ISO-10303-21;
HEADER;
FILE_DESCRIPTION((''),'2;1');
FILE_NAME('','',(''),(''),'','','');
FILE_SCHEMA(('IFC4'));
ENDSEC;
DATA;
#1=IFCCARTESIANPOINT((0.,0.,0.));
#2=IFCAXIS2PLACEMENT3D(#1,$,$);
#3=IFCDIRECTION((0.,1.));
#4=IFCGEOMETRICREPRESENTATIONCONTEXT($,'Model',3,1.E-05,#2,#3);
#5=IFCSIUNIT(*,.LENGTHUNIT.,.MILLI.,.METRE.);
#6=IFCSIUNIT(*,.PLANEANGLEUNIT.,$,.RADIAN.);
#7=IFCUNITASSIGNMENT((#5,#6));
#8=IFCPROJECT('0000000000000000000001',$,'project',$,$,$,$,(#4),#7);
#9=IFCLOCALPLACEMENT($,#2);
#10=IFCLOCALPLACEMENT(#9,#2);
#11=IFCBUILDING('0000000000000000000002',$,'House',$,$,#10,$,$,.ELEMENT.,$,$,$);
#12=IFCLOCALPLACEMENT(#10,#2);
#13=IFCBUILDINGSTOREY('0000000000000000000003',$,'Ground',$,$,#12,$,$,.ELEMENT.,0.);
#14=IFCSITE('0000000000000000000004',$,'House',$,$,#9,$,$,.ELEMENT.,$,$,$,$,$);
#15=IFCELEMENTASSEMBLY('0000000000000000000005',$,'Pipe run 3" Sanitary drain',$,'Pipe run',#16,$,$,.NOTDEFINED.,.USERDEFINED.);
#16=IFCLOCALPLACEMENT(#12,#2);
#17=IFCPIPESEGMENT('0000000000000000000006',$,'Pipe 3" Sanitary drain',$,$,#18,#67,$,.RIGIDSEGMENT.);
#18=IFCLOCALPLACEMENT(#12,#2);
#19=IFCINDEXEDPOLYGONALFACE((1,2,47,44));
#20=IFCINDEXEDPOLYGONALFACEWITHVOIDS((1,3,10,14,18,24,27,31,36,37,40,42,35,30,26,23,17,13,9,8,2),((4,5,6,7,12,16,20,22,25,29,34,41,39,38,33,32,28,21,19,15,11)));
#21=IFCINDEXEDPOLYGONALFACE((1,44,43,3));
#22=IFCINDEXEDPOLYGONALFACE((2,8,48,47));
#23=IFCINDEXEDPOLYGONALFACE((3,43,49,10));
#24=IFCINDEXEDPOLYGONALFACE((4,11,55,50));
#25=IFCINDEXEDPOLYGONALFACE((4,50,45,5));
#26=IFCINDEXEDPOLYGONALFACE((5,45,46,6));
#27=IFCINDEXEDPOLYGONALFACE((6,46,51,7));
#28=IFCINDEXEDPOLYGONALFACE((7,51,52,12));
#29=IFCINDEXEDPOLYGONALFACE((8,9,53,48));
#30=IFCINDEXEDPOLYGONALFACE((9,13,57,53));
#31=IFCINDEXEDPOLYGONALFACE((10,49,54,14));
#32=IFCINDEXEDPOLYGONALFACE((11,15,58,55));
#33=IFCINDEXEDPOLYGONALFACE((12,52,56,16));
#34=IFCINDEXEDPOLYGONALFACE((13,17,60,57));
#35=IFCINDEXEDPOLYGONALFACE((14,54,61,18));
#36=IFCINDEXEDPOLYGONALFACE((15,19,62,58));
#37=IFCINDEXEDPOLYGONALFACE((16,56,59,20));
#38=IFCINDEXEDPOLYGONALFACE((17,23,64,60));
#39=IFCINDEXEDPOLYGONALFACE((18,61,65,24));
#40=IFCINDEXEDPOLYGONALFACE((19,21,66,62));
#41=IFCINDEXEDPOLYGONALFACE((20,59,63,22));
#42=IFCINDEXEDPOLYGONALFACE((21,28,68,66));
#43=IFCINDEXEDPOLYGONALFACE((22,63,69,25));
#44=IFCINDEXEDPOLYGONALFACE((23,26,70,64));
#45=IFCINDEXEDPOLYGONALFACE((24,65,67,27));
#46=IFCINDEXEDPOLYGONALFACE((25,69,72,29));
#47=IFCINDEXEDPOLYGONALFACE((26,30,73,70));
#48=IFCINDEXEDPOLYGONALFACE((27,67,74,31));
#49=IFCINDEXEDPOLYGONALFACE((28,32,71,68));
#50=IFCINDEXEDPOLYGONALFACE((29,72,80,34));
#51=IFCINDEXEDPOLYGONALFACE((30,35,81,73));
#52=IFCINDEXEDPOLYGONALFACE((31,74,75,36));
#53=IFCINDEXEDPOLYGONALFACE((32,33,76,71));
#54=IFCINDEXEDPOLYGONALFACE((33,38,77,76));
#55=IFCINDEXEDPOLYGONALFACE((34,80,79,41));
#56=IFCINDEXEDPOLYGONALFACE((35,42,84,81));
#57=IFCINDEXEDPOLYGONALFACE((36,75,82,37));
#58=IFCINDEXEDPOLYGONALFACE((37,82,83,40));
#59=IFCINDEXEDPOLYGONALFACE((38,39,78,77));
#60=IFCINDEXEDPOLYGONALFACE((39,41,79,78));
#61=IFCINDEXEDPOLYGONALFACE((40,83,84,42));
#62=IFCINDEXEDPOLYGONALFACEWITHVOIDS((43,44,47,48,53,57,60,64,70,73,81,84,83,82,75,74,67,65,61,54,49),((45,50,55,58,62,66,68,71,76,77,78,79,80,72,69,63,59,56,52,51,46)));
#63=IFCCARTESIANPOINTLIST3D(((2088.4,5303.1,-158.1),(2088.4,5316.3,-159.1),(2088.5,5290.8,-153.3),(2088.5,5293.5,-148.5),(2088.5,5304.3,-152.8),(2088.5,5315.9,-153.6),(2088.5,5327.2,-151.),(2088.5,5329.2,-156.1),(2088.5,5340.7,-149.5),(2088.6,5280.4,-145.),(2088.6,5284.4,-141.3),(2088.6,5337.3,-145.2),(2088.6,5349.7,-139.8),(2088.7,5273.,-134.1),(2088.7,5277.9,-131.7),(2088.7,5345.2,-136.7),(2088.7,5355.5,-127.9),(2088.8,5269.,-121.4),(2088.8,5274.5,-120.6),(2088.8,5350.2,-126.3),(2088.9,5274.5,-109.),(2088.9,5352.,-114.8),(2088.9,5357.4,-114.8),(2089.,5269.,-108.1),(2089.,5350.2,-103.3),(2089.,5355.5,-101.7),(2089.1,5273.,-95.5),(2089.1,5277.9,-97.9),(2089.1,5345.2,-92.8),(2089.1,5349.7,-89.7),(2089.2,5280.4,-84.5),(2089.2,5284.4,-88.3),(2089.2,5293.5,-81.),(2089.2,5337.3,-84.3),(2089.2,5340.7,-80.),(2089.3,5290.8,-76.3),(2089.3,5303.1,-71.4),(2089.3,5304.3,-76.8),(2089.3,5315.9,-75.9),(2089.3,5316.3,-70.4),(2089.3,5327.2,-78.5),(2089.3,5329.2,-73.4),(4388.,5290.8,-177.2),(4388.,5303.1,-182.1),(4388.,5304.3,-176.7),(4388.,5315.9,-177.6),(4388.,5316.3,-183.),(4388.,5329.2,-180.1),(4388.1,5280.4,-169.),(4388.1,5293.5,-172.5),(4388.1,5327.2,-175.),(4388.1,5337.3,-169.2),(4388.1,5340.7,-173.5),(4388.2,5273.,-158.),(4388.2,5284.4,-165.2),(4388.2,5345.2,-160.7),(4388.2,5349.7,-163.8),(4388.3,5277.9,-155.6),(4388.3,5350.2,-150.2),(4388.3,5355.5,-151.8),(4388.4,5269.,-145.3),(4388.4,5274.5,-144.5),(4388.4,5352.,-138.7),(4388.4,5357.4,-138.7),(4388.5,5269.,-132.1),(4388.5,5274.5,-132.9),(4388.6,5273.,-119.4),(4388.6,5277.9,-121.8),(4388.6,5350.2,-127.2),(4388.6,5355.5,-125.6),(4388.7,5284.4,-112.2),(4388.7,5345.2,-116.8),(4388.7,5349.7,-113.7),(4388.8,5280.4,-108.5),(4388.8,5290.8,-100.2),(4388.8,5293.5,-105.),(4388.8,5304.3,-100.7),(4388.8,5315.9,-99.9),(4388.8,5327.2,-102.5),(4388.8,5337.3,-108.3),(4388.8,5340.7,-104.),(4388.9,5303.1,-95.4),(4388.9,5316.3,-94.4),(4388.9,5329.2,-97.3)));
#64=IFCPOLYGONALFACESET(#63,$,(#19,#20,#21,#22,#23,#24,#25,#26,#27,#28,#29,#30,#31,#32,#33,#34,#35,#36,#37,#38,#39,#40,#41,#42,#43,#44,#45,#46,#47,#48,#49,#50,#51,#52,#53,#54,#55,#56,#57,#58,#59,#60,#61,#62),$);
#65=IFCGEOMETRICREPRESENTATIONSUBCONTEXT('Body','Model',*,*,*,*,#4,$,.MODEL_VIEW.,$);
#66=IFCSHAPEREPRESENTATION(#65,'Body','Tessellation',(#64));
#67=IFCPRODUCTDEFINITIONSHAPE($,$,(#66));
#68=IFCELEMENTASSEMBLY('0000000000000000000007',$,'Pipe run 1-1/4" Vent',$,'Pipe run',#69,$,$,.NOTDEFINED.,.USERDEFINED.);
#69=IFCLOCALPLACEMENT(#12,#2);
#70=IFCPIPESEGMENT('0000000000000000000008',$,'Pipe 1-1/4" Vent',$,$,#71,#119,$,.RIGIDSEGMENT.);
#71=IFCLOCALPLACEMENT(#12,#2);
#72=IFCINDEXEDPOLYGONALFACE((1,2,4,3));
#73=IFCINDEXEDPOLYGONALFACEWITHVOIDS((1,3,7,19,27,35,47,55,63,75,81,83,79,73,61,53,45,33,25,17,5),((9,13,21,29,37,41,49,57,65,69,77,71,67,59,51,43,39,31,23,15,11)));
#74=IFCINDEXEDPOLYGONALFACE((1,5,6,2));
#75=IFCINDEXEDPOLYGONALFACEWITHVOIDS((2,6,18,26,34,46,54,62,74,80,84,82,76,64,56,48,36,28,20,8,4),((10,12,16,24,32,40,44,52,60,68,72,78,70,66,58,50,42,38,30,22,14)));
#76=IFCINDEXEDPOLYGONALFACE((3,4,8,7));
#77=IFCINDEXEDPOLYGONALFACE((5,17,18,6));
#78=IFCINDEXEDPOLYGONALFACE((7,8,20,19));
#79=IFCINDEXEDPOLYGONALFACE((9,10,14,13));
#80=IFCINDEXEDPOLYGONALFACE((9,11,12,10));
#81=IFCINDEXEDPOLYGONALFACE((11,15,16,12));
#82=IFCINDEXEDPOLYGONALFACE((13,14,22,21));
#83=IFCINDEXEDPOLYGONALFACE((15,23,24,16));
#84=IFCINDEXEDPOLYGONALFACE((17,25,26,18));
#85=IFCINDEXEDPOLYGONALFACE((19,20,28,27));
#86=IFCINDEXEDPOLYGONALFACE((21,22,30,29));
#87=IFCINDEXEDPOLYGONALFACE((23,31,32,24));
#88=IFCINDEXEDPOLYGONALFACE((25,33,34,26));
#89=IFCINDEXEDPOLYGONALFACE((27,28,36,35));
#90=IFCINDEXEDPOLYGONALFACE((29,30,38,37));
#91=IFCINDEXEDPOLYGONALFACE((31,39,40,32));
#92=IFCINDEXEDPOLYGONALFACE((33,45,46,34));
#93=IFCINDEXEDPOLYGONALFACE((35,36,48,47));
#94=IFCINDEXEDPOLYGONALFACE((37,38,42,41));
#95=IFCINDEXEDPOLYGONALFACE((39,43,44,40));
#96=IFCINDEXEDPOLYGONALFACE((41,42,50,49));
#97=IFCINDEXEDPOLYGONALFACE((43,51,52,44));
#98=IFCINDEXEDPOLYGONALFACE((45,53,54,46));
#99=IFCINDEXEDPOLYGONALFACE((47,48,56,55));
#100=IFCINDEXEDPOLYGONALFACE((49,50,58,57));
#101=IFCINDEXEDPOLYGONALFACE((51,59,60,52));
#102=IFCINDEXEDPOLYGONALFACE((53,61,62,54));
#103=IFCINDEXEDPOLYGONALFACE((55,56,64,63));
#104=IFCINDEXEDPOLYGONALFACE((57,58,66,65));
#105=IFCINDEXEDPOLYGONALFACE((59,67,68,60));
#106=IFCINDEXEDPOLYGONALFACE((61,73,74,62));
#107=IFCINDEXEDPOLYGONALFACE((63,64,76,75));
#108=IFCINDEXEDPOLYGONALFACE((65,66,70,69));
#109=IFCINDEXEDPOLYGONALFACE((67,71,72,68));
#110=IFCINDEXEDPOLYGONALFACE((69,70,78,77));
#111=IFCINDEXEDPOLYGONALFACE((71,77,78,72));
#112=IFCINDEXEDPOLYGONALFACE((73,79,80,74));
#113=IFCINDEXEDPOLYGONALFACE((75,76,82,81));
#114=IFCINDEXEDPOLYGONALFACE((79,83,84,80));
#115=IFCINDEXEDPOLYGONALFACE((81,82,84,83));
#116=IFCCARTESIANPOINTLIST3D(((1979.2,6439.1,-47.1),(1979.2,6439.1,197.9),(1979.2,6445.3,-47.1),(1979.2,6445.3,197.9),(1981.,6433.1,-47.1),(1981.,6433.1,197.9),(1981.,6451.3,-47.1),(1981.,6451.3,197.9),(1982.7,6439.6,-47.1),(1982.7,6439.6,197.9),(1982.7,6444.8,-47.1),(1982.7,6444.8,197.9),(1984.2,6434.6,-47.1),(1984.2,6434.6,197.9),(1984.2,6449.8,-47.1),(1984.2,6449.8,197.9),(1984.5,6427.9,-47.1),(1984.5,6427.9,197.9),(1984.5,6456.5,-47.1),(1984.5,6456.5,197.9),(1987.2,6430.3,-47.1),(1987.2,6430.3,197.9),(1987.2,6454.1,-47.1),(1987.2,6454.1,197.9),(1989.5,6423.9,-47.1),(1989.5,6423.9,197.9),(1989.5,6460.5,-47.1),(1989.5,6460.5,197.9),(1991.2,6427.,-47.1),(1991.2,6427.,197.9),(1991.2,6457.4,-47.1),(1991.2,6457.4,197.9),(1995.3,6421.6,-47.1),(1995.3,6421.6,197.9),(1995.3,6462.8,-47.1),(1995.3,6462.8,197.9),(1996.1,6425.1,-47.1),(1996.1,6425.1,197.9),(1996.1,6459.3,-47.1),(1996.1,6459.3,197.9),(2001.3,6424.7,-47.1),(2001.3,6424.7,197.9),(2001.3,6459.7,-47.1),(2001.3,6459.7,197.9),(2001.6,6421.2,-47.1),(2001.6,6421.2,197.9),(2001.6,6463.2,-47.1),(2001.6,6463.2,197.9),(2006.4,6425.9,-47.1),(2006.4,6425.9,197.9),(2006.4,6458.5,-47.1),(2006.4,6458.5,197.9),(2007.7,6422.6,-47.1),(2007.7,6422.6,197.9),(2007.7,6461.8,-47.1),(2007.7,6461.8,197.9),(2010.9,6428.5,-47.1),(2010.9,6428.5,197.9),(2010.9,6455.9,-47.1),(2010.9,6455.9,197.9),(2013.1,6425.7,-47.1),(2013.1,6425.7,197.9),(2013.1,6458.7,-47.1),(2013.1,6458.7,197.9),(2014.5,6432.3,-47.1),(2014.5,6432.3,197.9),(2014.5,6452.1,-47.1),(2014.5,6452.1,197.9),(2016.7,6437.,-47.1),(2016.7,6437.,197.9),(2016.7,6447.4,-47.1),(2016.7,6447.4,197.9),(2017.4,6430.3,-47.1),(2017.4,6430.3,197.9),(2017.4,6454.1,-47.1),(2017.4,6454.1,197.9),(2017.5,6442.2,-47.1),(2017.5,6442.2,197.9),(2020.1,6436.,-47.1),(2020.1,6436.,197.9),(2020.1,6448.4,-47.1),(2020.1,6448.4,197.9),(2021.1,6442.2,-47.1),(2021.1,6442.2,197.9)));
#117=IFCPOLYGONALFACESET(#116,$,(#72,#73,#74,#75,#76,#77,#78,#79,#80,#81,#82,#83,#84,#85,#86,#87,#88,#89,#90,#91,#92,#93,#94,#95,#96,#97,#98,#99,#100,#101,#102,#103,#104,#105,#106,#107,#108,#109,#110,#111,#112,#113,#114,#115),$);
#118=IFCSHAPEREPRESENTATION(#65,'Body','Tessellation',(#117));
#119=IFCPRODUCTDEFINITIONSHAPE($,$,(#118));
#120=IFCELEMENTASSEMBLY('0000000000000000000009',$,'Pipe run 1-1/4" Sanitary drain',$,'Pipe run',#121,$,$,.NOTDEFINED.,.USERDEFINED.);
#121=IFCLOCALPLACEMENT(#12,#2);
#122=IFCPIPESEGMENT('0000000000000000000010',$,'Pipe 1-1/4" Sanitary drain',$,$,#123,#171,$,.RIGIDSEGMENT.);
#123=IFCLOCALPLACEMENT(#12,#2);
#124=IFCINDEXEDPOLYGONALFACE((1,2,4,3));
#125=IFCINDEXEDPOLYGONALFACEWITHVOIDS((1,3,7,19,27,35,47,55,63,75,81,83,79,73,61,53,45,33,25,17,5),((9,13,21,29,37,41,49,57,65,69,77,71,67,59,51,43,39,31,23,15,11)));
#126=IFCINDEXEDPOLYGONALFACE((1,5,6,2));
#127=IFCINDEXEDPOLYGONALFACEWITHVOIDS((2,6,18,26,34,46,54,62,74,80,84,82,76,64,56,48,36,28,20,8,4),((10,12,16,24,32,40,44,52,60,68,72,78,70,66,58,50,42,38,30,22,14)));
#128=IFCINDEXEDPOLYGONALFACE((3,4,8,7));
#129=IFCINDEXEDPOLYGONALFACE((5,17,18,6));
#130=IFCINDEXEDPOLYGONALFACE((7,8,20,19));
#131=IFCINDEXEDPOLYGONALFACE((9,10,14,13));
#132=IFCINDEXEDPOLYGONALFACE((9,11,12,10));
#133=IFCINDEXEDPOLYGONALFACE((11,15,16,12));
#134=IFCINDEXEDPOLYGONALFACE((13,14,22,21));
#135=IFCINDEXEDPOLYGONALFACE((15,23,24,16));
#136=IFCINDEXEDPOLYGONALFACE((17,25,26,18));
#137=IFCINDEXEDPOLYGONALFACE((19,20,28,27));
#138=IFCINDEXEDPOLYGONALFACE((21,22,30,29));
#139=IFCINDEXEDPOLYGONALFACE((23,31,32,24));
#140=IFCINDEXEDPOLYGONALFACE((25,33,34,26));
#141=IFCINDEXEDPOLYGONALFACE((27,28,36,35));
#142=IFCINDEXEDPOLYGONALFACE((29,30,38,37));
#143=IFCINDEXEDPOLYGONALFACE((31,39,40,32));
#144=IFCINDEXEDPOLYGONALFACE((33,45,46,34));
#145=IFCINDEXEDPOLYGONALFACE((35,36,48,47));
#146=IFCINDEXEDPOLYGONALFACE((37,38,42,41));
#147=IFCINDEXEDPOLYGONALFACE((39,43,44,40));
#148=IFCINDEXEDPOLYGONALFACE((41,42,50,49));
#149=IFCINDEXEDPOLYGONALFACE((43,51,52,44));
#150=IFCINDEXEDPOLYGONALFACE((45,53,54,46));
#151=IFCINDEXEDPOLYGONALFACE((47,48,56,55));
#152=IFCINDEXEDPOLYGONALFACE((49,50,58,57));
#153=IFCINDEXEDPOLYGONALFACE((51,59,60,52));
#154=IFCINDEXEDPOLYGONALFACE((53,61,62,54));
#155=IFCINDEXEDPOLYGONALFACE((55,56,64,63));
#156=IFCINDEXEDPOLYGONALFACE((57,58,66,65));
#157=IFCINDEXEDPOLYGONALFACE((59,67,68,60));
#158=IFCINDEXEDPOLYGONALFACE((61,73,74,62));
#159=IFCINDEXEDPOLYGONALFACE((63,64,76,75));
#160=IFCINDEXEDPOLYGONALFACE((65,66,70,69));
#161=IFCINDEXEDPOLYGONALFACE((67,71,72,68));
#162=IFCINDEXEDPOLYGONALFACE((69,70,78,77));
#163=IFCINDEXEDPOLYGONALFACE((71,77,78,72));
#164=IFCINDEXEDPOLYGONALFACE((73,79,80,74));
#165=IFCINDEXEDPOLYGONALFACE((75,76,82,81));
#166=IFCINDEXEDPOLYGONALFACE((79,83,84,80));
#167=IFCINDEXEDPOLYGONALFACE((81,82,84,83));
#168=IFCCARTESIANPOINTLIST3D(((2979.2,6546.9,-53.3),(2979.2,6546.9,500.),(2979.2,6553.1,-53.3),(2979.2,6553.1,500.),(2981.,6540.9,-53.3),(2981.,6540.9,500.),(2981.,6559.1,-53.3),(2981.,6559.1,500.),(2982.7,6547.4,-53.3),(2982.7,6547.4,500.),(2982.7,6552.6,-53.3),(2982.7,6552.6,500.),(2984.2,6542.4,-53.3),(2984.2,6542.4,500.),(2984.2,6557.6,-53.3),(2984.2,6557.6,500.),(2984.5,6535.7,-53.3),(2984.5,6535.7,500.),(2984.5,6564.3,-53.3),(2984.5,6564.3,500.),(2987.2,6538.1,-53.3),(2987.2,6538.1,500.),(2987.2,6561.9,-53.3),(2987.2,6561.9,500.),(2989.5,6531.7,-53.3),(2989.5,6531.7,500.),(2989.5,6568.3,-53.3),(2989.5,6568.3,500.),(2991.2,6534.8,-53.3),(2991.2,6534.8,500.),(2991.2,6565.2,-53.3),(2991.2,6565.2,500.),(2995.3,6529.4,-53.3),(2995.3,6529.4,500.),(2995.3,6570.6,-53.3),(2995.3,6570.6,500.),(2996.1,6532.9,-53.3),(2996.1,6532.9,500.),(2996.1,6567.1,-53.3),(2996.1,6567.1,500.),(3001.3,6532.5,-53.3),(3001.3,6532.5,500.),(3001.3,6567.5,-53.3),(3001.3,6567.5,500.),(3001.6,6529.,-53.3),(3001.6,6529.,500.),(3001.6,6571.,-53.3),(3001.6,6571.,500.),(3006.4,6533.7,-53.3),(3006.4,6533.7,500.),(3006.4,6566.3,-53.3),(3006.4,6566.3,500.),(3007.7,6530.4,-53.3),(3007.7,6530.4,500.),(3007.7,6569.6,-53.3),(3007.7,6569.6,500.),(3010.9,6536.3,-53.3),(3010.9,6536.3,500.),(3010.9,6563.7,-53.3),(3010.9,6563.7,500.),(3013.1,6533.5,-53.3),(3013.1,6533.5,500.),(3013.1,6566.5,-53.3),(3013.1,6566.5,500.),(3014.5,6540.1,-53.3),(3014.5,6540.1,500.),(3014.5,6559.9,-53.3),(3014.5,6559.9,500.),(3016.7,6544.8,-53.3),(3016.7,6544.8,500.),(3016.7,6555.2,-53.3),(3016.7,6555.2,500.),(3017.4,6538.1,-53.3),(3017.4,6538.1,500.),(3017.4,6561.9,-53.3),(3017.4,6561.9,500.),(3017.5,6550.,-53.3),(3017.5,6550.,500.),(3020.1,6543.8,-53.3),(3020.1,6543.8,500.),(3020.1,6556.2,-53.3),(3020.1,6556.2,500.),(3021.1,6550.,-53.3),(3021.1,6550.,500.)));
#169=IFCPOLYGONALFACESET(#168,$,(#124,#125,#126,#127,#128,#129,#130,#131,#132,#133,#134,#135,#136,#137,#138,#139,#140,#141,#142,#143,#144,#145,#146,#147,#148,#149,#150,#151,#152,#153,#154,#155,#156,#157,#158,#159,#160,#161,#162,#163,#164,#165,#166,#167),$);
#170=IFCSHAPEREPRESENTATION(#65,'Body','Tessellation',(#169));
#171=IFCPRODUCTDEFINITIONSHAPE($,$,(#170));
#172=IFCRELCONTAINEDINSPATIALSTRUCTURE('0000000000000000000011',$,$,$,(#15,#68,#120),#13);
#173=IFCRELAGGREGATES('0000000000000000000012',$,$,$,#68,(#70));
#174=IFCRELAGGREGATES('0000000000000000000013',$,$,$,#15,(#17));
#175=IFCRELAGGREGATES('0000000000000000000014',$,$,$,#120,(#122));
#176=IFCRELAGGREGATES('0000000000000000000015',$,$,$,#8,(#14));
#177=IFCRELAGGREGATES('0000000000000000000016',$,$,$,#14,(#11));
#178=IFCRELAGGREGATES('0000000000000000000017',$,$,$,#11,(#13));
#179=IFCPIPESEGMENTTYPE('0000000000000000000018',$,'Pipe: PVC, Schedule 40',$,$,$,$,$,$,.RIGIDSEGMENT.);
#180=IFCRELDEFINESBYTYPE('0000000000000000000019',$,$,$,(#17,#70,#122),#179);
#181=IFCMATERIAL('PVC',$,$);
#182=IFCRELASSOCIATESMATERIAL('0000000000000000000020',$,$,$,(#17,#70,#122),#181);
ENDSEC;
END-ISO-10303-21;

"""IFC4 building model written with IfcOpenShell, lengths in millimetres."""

from ifc_helpers import new_model, si_unit, direction, frame, origin, origin_with_axes, origin_2d, place, context, subcontext, project, spatial, hollow_circle, extrude, material, type_object, element, aggregate, save


model = new_model("IFC4")

# Units and contexts
model_context = context("Model", 3, precision=1e-05, world=origin(), true_north=direction((0.0, 1.0)))
body_context = subcontext(model_context, "Body", "Model", "MODEL_VIEW")
ifc_project = project(units=[si_unit("LENGTHUNIT", "METRE", prefix="MILLI"), si_unit("PLANEANGLEUNIT", "RADIAN")], contexts=[model_context])

# Site, building, storey
site_placement = place(None, origin())
site = spatial("IfcSite", under=ifc_project, at=site_placement, Name="House", CompositionType="ELEMENT")
building_placement = place(site_placement, origin())
building = spatial("IfcBuilding", under=site, at=building_placement, Name="House", CompositionType="ELEMENT")
storey_placement = place(building_placement, origin())
storey = spatial("IfcBuildingStorey", under=building, at=storey_placement, Name="Ground", CompositionType="ELEMENT", Elevation=0.0)

# Shared definitions
ifc_material = material(Name="PVC")
pipe_segment_type = type_object("IfcPipeSegmentType", Name="Pipe: PVC, Schedule 40", PredefinedType="RIGIDSEGMENT")

# Element assembly, pipe segment
assembly_1_placement = place(storey_placement, origin_with_axes())
assembly_1 = element("IfcElementAssembly", 1, at=assembly_1_placement, inside=storey, Name="Pipe run 3\" Sanitary drain", ObjectType="Pipe run", AssemblyPlace="NOTDEFINED", PredefinedType="USERDEFINED")
pipe_segment_1_placement = place(storey_placement, origin_with_axes())
pipe_segment_1 = element("IfcPipeSegment", 2, at=pipe_segment_1_placement, type_object=pipe_segment_type, material=ifc_material, Name="Pipe 3\" Sanitary drain", PredefinedType="RIGIDSEGMENT", context=body_context, shape_type="SweptSolid", body=[
    extrude(hollow_circle(Radius=44.5, WallThickness=5.5, at=origin_2d()), frame((2088.9, 5313.0, -114.8), z_axis=(0.999946, 0.0, -0.010416), x_axis=(0.0, 1.0, 0.0)), (0.0, 0.0, 1.0), 2299.7),
])

# Element assembly, pipe segment
assembly_2_placement = place(storey_placement, origin_with_axes())
assembly_2 = element("IfcElementAssembly", 3, at=assembly_2_placement, inside=storey, Name="Pipe run 1-1/4\" Vent", ObjectType="Pipe run", AssemblyPlace="NOTDEFINED", PredefinedType="USERDEFINED")
pipe_segment_2_placement = place(storey_placement, origin_with_axes())
pipe_segment_2 = element("IfcPipeSegment", 4, at=pipe_segment_2_placement, type_object=pipe_segment_type, material=ifc_material, Name="Pipe 1-1/4\" Vent", PredefinedType="RIGIDSEGMENT", context=body_context, shape_type="SweptSolid", body=[
    extrude(hollow_circle(Radius=21.1, WallThickness=3.6, at=origin_2d()), frame((2000.0, 6442.2, 197.9), z_axis=(0.0, 0.0, -1.0), x_axis=(1.0, 0.0, 0.0)), (0.0, 0.0, 1.0), 245.0),
])
aggregate(assembly_2, [pipe_segment_2])

# Element assembly, pipe segment
assembly_3_placement = place(storey_placement, origin_with_axes())
assembly_3 = element("IfcElementAssembly", 5, at=assembly_3_placement, inside=storey, Name="Pipe run 1-1/4\" Sanitary drain", ObjectType="Pipe run", AssemblyPlace="NOTDEFINED", PredefinedType="USERDEFINED")
pipe_segment_3_placement = place(storey_placement, origin_with_axes())
pipe_segment_3 = element("IfcPipeSegment", 6, at=pipe_segment_3_placement, type_object=pipe_segment_type, material=ifc_material, Name="Pipe 1-1/4\" Sanitary drain", PredefinedType="RIGIDSEGMENT", context=body_context, shape_type="SweptSolid", body=[
    extrude(hollow_circle(Radius=21.1, WallThickness=3.6, at=origin_2d()), frame((3000.0, 6550.0, 500.0), z_axis=(0.0, 0.0, -1.0), x_axis=(1.0, 0.0, 0.0)), (0.0, 0.0, 1.0), 553.3),
])

aggregate(assembly_1, [pipe_segment_1])
aggregate(assembly_3, [pipe_segment_3])

save(model, "model.ifc")
